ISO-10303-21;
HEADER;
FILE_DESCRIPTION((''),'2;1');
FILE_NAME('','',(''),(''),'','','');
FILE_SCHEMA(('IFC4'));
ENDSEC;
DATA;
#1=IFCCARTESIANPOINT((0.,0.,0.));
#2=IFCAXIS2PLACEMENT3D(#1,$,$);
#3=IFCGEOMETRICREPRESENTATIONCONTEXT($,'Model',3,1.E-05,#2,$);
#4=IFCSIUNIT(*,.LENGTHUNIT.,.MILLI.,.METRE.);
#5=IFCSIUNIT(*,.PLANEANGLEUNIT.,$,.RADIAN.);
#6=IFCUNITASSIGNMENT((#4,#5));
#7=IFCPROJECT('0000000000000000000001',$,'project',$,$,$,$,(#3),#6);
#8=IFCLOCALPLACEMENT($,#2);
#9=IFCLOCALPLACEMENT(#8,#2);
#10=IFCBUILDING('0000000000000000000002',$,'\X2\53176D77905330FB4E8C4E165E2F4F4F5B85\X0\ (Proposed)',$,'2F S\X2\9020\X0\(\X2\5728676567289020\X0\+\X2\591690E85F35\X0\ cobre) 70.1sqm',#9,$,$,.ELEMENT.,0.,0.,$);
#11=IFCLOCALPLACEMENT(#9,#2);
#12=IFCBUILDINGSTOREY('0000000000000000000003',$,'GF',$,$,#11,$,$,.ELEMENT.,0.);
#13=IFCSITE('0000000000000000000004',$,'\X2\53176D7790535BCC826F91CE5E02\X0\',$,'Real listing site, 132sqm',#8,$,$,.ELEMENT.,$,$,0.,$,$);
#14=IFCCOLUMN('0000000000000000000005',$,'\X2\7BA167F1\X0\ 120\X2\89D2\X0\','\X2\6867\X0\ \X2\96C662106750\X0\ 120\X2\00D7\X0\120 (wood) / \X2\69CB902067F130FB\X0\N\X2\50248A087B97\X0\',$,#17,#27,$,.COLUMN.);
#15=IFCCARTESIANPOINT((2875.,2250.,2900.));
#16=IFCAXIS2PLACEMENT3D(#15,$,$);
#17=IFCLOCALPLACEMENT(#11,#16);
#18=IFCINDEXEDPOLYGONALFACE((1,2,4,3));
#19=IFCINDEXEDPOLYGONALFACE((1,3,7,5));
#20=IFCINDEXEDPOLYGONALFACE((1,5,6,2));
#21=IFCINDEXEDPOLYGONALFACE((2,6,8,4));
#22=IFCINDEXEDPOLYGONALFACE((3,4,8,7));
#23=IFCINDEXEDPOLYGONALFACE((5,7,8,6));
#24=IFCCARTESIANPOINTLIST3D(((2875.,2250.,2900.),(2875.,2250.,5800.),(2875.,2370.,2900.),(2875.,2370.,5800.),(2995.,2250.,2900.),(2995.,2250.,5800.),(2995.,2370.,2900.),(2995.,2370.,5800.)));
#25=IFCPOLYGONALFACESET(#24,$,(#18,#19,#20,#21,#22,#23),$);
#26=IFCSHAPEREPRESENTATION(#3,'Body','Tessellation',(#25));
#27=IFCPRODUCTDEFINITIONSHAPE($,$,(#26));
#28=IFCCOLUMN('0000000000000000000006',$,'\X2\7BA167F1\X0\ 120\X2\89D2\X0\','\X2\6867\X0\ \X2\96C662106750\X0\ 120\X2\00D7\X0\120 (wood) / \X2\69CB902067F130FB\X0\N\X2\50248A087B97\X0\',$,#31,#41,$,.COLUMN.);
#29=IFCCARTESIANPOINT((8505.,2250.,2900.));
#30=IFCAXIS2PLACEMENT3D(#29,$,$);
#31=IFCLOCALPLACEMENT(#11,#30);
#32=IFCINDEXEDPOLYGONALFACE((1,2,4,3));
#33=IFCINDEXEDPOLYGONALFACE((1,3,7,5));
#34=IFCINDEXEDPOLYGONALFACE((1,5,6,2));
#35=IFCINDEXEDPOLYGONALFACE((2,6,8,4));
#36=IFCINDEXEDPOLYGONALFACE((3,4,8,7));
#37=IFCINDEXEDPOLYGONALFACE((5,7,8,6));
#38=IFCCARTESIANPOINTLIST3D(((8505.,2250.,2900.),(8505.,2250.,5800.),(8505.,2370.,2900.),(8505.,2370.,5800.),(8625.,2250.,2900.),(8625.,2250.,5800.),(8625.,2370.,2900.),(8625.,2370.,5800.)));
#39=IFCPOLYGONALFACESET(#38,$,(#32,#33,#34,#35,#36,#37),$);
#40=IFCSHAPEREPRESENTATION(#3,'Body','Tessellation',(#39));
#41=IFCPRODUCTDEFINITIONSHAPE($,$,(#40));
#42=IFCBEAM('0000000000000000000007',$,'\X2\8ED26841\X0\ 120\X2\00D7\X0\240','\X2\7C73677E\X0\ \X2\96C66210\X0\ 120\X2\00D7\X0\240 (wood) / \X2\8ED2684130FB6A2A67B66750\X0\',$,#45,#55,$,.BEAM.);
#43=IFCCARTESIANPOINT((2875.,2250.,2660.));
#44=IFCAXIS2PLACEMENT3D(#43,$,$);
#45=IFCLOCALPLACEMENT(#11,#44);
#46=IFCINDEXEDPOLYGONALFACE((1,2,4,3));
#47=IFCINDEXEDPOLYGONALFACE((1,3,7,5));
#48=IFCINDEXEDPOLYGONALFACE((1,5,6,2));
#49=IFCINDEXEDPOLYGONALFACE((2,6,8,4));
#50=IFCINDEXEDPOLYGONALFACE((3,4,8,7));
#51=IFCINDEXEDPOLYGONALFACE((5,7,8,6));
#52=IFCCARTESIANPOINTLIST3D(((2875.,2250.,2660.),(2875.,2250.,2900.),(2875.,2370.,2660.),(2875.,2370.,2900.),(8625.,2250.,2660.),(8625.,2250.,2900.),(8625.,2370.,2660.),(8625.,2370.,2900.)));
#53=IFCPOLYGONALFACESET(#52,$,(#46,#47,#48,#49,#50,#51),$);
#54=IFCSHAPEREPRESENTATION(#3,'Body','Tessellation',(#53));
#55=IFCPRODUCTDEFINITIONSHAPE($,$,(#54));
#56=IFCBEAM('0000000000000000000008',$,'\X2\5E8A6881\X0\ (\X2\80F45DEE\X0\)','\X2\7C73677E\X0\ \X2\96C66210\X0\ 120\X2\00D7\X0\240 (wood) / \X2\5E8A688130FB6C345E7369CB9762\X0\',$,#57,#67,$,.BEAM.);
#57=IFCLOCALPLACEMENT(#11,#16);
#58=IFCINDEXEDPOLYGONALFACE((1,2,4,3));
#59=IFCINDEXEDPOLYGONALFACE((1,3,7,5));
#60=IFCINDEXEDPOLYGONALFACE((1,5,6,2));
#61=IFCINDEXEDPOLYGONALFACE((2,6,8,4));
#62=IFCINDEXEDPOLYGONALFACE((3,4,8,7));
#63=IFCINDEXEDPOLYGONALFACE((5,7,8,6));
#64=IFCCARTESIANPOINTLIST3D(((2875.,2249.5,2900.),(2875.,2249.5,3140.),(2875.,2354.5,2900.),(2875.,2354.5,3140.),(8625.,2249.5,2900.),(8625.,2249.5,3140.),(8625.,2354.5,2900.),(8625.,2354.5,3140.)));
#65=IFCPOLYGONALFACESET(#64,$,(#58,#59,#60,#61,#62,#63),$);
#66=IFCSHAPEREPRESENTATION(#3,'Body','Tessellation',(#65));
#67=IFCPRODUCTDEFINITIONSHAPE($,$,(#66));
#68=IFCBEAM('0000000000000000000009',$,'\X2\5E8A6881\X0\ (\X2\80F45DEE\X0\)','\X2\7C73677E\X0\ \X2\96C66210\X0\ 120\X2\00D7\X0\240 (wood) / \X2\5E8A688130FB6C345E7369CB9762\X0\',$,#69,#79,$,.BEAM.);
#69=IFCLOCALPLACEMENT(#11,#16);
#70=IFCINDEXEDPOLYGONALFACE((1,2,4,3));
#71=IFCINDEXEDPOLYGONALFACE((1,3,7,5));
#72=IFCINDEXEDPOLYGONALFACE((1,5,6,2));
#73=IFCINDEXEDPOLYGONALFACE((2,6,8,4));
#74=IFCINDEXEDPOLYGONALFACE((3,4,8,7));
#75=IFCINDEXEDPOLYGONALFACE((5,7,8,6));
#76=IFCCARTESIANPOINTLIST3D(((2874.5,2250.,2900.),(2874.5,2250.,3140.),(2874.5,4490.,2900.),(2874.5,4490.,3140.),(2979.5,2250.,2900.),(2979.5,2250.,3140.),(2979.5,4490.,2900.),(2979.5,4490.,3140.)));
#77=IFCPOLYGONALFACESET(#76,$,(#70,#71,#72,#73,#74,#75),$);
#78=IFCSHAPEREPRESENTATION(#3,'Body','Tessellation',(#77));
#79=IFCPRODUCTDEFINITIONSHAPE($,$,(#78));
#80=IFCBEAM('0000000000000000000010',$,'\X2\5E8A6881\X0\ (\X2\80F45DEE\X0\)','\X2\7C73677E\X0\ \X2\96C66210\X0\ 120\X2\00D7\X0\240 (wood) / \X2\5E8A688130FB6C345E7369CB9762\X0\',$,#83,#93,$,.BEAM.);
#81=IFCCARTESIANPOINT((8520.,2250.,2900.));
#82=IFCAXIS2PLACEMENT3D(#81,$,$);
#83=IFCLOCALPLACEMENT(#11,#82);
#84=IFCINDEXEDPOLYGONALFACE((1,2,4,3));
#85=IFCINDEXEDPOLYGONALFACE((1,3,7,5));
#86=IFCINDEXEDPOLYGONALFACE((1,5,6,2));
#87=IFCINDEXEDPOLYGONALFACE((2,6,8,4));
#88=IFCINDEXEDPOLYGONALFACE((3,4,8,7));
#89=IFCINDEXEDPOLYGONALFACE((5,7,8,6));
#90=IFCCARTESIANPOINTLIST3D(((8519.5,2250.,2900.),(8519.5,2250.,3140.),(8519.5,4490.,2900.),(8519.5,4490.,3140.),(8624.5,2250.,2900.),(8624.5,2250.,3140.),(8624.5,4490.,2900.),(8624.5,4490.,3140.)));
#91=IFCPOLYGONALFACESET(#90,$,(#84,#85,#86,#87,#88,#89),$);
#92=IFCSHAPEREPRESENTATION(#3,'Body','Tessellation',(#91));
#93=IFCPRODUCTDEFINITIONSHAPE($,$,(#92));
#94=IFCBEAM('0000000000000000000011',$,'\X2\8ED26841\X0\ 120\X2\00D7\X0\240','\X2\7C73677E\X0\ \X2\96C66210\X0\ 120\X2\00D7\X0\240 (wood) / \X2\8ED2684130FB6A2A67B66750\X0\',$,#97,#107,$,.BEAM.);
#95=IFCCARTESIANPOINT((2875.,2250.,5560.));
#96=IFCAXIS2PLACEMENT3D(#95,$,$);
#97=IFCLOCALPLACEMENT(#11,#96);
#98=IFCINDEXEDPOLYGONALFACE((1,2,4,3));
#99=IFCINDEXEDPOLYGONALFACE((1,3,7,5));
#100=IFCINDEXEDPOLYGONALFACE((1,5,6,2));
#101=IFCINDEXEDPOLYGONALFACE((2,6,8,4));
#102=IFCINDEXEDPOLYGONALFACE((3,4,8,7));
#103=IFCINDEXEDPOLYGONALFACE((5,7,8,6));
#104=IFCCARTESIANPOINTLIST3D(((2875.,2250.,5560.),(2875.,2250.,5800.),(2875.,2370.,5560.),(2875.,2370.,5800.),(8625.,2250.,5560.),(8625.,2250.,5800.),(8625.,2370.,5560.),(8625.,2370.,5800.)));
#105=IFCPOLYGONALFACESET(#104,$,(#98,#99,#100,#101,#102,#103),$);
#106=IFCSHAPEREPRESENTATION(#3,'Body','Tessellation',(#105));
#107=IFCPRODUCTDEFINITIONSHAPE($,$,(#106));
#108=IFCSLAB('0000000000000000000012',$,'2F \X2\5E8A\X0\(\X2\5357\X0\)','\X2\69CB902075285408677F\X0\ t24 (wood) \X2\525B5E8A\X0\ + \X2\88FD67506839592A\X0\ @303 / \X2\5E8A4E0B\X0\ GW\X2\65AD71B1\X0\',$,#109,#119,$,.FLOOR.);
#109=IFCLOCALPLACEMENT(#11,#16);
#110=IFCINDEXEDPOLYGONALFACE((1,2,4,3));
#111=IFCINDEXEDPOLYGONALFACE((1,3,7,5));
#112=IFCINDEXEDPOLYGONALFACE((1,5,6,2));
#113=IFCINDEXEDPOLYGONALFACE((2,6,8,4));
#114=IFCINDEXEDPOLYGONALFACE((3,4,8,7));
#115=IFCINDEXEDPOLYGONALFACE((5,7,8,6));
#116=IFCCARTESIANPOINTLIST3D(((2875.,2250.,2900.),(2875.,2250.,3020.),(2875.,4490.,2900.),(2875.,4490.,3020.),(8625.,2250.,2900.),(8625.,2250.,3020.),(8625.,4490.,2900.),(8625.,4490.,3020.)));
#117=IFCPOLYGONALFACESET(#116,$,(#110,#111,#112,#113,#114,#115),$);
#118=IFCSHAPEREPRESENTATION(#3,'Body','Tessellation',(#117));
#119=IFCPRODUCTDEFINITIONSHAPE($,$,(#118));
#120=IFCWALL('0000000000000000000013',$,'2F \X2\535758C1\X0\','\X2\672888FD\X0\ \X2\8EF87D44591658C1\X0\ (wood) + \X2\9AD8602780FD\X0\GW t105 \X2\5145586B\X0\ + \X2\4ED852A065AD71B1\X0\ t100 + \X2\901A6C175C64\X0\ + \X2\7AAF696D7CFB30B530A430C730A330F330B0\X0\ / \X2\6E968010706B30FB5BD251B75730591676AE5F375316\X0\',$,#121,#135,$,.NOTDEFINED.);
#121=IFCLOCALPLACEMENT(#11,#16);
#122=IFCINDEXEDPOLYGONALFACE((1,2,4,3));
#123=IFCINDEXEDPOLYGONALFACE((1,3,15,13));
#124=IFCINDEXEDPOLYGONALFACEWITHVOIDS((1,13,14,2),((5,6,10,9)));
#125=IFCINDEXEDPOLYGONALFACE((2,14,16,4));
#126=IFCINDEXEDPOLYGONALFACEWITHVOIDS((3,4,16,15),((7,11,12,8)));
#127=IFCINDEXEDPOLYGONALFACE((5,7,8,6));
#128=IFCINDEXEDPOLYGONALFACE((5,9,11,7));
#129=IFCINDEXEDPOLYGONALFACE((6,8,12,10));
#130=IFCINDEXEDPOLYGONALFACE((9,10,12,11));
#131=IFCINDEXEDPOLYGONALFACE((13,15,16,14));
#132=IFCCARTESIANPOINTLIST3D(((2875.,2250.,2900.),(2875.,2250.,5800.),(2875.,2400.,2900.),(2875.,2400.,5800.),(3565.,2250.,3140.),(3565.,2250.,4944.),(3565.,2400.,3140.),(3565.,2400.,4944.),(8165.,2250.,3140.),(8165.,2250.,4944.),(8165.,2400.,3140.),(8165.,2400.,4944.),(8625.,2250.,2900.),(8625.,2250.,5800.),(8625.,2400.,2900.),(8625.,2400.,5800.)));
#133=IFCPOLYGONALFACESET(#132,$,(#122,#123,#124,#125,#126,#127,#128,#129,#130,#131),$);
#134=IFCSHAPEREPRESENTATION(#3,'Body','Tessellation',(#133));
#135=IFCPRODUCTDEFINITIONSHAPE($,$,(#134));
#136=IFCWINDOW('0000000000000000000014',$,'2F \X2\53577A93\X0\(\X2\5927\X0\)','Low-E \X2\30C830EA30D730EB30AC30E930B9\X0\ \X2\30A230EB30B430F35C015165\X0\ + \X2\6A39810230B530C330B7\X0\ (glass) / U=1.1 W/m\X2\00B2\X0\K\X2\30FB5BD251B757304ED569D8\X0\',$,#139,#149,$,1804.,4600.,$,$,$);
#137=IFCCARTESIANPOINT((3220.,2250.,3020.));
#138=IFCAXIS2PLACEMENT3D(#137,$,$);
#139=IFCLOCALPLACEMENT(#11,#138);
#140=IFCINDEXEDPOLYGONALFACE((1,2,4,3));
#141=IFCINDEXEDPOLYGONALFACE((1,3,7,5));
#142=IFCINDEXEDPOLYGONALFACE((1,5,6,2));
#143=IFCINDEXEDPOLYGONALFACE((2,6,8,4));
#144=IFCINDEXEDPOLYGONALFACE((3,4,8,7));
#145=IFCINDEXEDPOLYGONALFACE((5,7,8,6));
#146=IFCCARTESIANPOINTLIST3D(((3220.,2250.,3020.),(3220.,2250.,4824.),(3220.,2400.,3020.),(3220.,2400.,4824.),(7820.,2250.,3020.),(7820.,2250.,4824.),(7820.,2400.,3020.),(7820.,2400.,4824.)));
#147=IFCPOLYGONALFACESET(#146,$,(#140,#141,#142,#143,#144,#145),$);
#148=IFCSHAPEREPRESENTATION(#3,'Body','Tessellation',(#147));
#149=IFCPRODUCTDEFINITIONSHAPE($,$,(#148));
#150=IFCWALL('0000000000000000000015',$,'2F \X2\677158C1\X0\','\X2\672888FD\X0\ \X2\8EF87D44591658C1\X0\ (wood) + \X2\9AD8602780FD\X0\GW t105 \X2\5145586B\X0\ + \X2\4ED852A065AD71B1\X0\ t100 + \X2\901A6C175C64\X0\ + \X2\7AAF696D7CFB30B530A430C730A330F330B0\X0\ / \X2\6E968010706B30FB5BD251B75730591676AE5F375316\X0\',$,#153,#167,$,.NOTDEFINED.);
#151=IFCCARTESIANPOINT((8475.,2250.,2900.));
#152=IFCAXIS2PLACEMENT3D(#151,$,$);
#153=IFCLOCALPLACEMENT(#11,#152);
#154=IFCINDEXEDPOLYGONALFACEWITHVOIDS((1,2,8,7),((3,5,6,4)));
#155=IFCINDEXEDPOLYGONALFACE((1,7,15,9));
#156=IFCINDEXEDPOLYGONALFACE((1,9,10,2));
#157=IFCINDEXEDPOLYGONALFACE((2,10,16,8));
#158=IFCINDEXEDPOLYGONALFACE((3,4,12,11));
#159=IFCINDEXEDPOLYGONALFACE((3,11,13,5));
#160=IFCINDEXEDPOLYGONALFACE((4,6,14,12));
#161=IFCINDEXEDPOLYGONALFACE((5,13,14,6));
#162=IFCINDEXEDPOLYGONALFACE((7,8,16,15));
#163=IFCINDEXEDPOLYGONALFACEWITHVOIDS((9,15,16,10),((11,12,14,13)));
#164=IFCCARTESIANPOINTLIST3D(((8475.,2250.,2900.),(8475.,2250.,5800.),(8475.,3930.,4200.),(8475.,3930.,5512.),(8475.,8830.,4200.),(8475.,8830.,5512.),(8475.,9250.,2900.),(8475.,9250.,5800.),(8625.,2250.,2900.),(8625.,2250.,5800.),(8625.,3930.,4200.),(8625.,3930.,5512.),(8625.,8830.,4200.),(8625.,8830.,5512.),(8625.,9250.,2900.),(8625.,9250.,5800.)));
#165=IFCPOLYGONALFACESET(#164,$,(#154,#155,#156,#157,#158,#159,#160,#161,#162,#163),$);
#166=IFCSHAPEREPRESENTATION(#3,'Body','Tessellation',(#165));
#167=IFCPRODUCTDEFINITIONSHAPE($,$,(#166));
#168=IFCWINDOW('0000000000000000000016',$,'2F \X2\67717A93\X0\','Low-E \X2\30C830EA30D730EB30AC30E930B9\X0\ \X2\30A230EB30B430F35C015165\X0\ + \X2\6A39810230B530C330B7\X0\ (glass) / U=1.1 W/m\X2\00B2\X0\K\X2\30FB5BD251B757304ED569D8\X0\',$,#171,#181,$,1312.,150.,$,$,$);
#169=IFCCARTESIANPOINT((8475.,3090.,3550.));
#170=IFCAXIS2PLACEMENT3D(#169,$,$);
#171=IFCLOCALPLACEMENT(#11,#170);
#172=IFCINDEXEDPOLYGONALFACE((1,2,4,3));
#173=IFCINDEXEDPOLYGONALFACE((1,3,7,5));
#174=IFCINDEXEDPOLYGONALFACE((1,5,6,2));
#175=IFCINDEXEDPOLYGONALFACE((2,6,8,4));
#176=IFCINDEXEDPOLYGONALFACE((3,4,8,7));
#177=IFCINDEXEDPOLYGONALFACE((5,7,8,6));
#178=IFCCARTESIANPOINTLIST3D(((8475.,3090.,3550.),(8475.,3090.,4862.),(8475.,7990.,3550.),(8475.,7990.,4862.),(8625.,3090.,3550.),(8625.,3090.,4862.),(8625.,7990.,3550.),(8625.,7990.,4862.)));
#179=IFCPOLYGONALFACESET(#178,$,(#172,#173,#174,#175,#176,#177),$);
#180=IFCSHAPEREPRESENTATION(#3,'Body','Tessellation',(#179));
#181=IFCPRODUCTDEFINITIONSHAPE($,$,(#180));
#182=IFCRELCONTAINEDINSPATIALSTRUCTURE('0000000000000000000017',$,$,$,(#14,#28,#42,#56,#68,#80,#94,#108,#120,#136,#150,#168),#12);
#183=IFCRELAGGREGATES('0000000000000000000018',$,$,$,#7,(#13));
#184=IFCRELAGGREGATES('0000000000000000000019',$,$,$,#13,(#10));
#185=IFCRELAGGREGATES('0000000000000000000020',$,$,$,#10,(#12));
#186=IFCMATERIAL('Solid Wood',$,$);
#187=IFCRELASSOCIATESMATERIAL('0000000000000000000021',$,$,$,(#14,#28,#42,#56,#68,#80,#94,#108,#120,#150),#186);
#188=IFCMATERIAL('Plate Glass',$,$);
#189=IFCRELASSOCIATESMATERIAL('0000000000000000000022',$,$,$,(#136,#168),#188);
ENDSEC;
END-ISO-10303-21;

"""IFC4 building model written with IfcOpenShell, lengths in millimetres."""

from ifc_helpers import new_model, si_unit, frame, frame_2d, origin, place, context, project, spatial, rectangle, extrude, material, element, fill, save


model = new_model("IFC4")

# Units and contexts
model_context = context("Model", 3, precision=1e-05, world=origin())
ifc_project = project(units=[si_unit("LENGTHUNIT", "METRE", prefix="MILLI"), si_unit("PLANEANGLEUNIT", "RADIAN")], contexts=[model_context])

# Site, building, storey
site_placement = place(None, origin())
site = spatial("IfcSite", under=ifc_project, at=site_placement, Name="北海道富良野市", ObjectType="Real listing site, 132sqm", CompositionType="ELEMENT", RefElevation=0.0)
building_placement = place(site_placement, origin())
building = spatial("IfcBuilding", under=site, at=building_placement, Name="北海道・二世帯住宅 (Proposed)", ObjectType="2F S造(在来木造+外部張 cobre) 70.1sqm", CompositionType="ELEMENT", ElevationOfRefHeight=0.0, ElevationOfTerrain=0.0)
storey_placement = place(building_placement, origin())
storey = spatial("IfcBuildingStorey", under=building, at=storey_placement, Name="GF", CompositionType="ELEMENT", Elevation=0.0)

# Columns
ifc_material_1 = material(Name="Solid Wood")
column_1_placement = place(storey_placement, frame((2875.0, 2250.0, 2900.0)))
element("IfcColumn", 1, at=column_1_placement, inside=storey, material=ifc_material_1, Name="管柱 120角", Description="桧 集成材 120×120 (wood) / 構造柱・N値計算", PredefinedType="COLUMN", context=model_context, shape_type="SweptSolid", body=[
    extrude(rectangle(XDim=120.0, YDim=120.0, at=frame_2d((60.0, 60.0))), frame((2875.0, 2250.0, 2900.0)), (0.0, 0.0, 1.0), 2900.0),
])
column_2_placement = place(storey_placement, frame((8505.0, 2250.0, 2900.0)))
element("IfcColumn", 2, at=column_2_placement, inside=storey, material=ifc_material_1, Name="管柱 120角", Description="桧 集成材 120×120 (wood) / 構造柱・N値計算", PredefinedType="COLUMN", context=model_context, shape_type="SweptSolid", body=[
    extrude(rectangle(XDim=120.0, YDim=120.0, at=frame_2d((60.0, 60.0))), frame((8505.0, 2250.0, 2900.0)), (0.0, 0.0, 1.0), 2900.0),
])

# Beams
beam_1_placement = place(storey_placement, frame((2875.0, 2250.0, 2660.0)))
element("IfcBeam", 3, at=beam_1_placement, inside=storey, material=ifc_material_1, Name="軒桁 120×240", Description="米松 集成 120×240 (wood) / 軒桁・横架材", PredefinedType="BEAM", context=model_context, shape_type="SweptSolid", body=[
    extrude(rectangle(XDim=5750.0, YDim=120.0, at=frame_2d((2875.0, 60.0))), frame((2875.0, 2250.0, 2660.0)), (0.0, 0.0, 1.0), 240.0),
])
beam_2_placement = place(storey_placement, frame((2875.0, 2250.0, 2900.0)))
element("IfcBeam", 4, at=beam_2_placement, inside=storey, material=ifc_material_1, Name="床梁 (胴差)", Description="米松 集成 120×240 (wood) / 床梁・水平構面", PredefinedType="BEAM", context=model_context, shape_type="SweptSolid", body=[
    extrude(rectangle(XDim=5750.0, YDim=105.0, at=frame_2d((2875.0, 52.0))), frame((2875.0, 2250.0, 2900.0)), (0.0, 0.0, 1.0), 240.0),
])
beam_3_placement = place(storey_placement, frame((2875.0, 2250.0, 2900.0)))
element("IfcBeam", 5, at=beam_3_placement, inside=storey, material=ifc_material_1, Name="床梁 (胴差)", Description="米松 集成 120×240 (wood) / 床梁・水平構面", PredefinedType="BEAM", context=model_context, shape_type="SweptSolid", body=[
    extrude(rectangle(XDim=105.0, YDim=2240.0, at=frame_2d((52.0, 1120.0))), frame((2875.0, 2250.0, 2900.0)), (0.0, 0.0, 1.0), 240.0),
])
beam_4_placement = place(storey_placement, frame((8520.0, 2250.0, 2900.0)))
element("IfcBeam", 6, at=beam_4_placement, inside=storey, material=ifc_material_1, Name="床梁 (胴差)", Description="米松 集成 120×240 (wood) / 床梁・水平構面", PredefinedType="BEAM", context=model_context, shape_type="SweptSolid", body=[
    extrude(rectangle(XDim=105.0, YDim=2240.0, at=frame_2d((52.0, 1120.0))), frame((8520.0, 2250.0, 2900.0)), (0.0, 0.0, 1.0), 240.0),
])
beam_5_placement = place(storey_placement, frame((2875.0, 2250.0, 5560.0)))
element("IfcBeam", 7, at=beam_5_placement, inside=storey, material=ifc_material_1, Name="軒桁 120×240", Description="米松 集成 120×240 (wood) / 軒桁・横架材", PredefinedType="BEAM", context=model_context, shape_type="SweptSolid", body=[
    extrude(rectangle(XDim=5750.0, YDim=120.0, at=frame_2d((2875.0, 60.0))), frame((2875.0, 2250.0, 5560.0)), (0.0, 0.0, 1.0), 240.0),
])

# Slab
slab_placement = place(storey_placement, frame((2875.0, 2250.0, 2900.0)))
element("IfcSlab", 8, at=slab_placement, inside=storey, material=ifc_material_1, Name="2F 床(南)", Description="構造用合板 t24 (wood) 剛床 + 製材根太 @303 / 床下 GW断熱", PredefinedType="FLOOR", context=model_context, shape_type="SweptSolid", body=[
    extrude(rectangle(XDim=5750.0, YDim=2240.0, at=frame_2d((2875.0, 1120.0))), frame((2875.0, 2250.0, 2900.0)), (0.0, 0.0, 1.0), 120.0),
])

# Walls, openings, windows
wall_1_placement = place(storey_placement, frame((2875.0, 2250.0, 2900.0)))
wall_1 = element("IfcWall", 9, at=wall_1_placement, inside=storey, material=ifc_material_1, Name="2F 南壁", Description="木製 軸組外壁 (wood) + 高性能GW t105 充填 + 付加断熱 t100 + 通気層 + 窯業系サイディング / 準耐火・寒冷地外皮強化", PredefinedType="NOTDEFINED", context=model_context, shape_type="SweptSolid", body=[
    extrude(rectangle(XDim=5750.0, YDim=150.0, at=frame_2d((2875.0, 75.0))), frame((2875.0, 2250.0, 2900.0)), (0.0, 0.0, 1.0), 2900.0),
])
opening_1_placement = place(storey_placement, frame((3220.0, 2250.0, 3020.0)))
opening_1 = element("IfcOpeningElement", 10, at=opening_1_placement, cuts=wall_1, PredefinedType="NOTDEFINED", context=model_context, shape_type="SweptSolid", body=[
    extrude(rectangle(XDim=4600.0, YDim=150.0, at=frame_2d((2300.0, 75.0))), frame((3220.0, 2250.0, 3020.0)), (0.0, 0.0, 1.0), 1804.0),
])
ifc_material_2 = material(Name="Plate Glass")
window_1_placement = place(storey_placement, frame((3220.0, 2250.0, 3020.0)))
window_1 = element("IfcWindow", 11, at=window_1_placement, inside=storey, material=ifc_material_2, Name="2F 南窓(大)", Description="Low-E トリプルガラス アルゴン封入 + 樹脂サッシ (glass) / U=1.1 W/m²K・寒冷地仕様", OverallHeight=1804.0, OverallWidth=4600.0, context=model_context, shape_type="SweptSolid", body=[
    extrude(rectangle(XDim=4600.0, YDim=150.0, at=frame_2d((2300.0, 75.0))), frame((3220.0, 2250.0, 3020.0)), (0.0, 0.0, 1.0), 1804.0),
])
fill(opening_1, window_1)
wall_2_placement = place(storey_placement, frame((8475.0, 2250.0, 2900.0)))
wall_2 = element("IfcWall", 12, at=wall_2_placement, inside=storey, material=ifc_material_1, Name="2F 東壁", Description="木製 軸組外壁 (wood) + 高性能GW t105 充填 + 付加断熱 t100 + 通気層 + 窯業系サイディング / 準耐火・寒冷地外皮強化", PredefinedType="NOTDEFINED", context=model_context, shape_type="SweptSolid", body=[
    extrude(rectangle(XDim=150.0, YDim=7000.0, at=frame_2d((75.0, 3500.0))), frame((8475.0, 2250.0, 2900.0)), (0.0, 0.0, 1.0), 2900.0),
])
opening_2_placement = place(storey_placement, frame((8475.0, 3090.0, 3550.0)))
opening_2 = element("IfcOpeningElement", 13, at=opening_2_placement, cuts=wall_2, PredefinedType="NOTDEFINED", context=model_context, shape_type="SweptSolid", body=[
    extrude(rectangle(XDim=150.0, YDim=4900.0, at=frame_2d((75.0, 2450.0))), frame((8475.0, 3090.0, 3550.0)), (0.0, 0.0, 1.0), 1312.0),
])
window_2_placement = place(storey_placement, frame((8475.0, 3090.0, 3550.0)))
window_2 = element("IfcWindow", 14, at=window_2_placement, inside=storey, material=ifc_material_2, Name="2F 東窓", Description="Low-E トリプルガラス アルゴン封入 + 樹脂サッシ (glass) / U=1.1 W/m²K・寒冷地仕様", OverallHeight=1312.0, OverallWidth=150.0, context=model_context, shape_type="SweptSolid", body=[
    extrude(rectangle(XDim=150.0, YDim=4900.0, at=frame_2d((75.0, 2450.0))), frame((8475.0, 3090.0, 3550.0)), (0.0, 0.0, 1.0), 1312.0),
])
fill(opening_2, window_2)

save(model, "model.ifc")
